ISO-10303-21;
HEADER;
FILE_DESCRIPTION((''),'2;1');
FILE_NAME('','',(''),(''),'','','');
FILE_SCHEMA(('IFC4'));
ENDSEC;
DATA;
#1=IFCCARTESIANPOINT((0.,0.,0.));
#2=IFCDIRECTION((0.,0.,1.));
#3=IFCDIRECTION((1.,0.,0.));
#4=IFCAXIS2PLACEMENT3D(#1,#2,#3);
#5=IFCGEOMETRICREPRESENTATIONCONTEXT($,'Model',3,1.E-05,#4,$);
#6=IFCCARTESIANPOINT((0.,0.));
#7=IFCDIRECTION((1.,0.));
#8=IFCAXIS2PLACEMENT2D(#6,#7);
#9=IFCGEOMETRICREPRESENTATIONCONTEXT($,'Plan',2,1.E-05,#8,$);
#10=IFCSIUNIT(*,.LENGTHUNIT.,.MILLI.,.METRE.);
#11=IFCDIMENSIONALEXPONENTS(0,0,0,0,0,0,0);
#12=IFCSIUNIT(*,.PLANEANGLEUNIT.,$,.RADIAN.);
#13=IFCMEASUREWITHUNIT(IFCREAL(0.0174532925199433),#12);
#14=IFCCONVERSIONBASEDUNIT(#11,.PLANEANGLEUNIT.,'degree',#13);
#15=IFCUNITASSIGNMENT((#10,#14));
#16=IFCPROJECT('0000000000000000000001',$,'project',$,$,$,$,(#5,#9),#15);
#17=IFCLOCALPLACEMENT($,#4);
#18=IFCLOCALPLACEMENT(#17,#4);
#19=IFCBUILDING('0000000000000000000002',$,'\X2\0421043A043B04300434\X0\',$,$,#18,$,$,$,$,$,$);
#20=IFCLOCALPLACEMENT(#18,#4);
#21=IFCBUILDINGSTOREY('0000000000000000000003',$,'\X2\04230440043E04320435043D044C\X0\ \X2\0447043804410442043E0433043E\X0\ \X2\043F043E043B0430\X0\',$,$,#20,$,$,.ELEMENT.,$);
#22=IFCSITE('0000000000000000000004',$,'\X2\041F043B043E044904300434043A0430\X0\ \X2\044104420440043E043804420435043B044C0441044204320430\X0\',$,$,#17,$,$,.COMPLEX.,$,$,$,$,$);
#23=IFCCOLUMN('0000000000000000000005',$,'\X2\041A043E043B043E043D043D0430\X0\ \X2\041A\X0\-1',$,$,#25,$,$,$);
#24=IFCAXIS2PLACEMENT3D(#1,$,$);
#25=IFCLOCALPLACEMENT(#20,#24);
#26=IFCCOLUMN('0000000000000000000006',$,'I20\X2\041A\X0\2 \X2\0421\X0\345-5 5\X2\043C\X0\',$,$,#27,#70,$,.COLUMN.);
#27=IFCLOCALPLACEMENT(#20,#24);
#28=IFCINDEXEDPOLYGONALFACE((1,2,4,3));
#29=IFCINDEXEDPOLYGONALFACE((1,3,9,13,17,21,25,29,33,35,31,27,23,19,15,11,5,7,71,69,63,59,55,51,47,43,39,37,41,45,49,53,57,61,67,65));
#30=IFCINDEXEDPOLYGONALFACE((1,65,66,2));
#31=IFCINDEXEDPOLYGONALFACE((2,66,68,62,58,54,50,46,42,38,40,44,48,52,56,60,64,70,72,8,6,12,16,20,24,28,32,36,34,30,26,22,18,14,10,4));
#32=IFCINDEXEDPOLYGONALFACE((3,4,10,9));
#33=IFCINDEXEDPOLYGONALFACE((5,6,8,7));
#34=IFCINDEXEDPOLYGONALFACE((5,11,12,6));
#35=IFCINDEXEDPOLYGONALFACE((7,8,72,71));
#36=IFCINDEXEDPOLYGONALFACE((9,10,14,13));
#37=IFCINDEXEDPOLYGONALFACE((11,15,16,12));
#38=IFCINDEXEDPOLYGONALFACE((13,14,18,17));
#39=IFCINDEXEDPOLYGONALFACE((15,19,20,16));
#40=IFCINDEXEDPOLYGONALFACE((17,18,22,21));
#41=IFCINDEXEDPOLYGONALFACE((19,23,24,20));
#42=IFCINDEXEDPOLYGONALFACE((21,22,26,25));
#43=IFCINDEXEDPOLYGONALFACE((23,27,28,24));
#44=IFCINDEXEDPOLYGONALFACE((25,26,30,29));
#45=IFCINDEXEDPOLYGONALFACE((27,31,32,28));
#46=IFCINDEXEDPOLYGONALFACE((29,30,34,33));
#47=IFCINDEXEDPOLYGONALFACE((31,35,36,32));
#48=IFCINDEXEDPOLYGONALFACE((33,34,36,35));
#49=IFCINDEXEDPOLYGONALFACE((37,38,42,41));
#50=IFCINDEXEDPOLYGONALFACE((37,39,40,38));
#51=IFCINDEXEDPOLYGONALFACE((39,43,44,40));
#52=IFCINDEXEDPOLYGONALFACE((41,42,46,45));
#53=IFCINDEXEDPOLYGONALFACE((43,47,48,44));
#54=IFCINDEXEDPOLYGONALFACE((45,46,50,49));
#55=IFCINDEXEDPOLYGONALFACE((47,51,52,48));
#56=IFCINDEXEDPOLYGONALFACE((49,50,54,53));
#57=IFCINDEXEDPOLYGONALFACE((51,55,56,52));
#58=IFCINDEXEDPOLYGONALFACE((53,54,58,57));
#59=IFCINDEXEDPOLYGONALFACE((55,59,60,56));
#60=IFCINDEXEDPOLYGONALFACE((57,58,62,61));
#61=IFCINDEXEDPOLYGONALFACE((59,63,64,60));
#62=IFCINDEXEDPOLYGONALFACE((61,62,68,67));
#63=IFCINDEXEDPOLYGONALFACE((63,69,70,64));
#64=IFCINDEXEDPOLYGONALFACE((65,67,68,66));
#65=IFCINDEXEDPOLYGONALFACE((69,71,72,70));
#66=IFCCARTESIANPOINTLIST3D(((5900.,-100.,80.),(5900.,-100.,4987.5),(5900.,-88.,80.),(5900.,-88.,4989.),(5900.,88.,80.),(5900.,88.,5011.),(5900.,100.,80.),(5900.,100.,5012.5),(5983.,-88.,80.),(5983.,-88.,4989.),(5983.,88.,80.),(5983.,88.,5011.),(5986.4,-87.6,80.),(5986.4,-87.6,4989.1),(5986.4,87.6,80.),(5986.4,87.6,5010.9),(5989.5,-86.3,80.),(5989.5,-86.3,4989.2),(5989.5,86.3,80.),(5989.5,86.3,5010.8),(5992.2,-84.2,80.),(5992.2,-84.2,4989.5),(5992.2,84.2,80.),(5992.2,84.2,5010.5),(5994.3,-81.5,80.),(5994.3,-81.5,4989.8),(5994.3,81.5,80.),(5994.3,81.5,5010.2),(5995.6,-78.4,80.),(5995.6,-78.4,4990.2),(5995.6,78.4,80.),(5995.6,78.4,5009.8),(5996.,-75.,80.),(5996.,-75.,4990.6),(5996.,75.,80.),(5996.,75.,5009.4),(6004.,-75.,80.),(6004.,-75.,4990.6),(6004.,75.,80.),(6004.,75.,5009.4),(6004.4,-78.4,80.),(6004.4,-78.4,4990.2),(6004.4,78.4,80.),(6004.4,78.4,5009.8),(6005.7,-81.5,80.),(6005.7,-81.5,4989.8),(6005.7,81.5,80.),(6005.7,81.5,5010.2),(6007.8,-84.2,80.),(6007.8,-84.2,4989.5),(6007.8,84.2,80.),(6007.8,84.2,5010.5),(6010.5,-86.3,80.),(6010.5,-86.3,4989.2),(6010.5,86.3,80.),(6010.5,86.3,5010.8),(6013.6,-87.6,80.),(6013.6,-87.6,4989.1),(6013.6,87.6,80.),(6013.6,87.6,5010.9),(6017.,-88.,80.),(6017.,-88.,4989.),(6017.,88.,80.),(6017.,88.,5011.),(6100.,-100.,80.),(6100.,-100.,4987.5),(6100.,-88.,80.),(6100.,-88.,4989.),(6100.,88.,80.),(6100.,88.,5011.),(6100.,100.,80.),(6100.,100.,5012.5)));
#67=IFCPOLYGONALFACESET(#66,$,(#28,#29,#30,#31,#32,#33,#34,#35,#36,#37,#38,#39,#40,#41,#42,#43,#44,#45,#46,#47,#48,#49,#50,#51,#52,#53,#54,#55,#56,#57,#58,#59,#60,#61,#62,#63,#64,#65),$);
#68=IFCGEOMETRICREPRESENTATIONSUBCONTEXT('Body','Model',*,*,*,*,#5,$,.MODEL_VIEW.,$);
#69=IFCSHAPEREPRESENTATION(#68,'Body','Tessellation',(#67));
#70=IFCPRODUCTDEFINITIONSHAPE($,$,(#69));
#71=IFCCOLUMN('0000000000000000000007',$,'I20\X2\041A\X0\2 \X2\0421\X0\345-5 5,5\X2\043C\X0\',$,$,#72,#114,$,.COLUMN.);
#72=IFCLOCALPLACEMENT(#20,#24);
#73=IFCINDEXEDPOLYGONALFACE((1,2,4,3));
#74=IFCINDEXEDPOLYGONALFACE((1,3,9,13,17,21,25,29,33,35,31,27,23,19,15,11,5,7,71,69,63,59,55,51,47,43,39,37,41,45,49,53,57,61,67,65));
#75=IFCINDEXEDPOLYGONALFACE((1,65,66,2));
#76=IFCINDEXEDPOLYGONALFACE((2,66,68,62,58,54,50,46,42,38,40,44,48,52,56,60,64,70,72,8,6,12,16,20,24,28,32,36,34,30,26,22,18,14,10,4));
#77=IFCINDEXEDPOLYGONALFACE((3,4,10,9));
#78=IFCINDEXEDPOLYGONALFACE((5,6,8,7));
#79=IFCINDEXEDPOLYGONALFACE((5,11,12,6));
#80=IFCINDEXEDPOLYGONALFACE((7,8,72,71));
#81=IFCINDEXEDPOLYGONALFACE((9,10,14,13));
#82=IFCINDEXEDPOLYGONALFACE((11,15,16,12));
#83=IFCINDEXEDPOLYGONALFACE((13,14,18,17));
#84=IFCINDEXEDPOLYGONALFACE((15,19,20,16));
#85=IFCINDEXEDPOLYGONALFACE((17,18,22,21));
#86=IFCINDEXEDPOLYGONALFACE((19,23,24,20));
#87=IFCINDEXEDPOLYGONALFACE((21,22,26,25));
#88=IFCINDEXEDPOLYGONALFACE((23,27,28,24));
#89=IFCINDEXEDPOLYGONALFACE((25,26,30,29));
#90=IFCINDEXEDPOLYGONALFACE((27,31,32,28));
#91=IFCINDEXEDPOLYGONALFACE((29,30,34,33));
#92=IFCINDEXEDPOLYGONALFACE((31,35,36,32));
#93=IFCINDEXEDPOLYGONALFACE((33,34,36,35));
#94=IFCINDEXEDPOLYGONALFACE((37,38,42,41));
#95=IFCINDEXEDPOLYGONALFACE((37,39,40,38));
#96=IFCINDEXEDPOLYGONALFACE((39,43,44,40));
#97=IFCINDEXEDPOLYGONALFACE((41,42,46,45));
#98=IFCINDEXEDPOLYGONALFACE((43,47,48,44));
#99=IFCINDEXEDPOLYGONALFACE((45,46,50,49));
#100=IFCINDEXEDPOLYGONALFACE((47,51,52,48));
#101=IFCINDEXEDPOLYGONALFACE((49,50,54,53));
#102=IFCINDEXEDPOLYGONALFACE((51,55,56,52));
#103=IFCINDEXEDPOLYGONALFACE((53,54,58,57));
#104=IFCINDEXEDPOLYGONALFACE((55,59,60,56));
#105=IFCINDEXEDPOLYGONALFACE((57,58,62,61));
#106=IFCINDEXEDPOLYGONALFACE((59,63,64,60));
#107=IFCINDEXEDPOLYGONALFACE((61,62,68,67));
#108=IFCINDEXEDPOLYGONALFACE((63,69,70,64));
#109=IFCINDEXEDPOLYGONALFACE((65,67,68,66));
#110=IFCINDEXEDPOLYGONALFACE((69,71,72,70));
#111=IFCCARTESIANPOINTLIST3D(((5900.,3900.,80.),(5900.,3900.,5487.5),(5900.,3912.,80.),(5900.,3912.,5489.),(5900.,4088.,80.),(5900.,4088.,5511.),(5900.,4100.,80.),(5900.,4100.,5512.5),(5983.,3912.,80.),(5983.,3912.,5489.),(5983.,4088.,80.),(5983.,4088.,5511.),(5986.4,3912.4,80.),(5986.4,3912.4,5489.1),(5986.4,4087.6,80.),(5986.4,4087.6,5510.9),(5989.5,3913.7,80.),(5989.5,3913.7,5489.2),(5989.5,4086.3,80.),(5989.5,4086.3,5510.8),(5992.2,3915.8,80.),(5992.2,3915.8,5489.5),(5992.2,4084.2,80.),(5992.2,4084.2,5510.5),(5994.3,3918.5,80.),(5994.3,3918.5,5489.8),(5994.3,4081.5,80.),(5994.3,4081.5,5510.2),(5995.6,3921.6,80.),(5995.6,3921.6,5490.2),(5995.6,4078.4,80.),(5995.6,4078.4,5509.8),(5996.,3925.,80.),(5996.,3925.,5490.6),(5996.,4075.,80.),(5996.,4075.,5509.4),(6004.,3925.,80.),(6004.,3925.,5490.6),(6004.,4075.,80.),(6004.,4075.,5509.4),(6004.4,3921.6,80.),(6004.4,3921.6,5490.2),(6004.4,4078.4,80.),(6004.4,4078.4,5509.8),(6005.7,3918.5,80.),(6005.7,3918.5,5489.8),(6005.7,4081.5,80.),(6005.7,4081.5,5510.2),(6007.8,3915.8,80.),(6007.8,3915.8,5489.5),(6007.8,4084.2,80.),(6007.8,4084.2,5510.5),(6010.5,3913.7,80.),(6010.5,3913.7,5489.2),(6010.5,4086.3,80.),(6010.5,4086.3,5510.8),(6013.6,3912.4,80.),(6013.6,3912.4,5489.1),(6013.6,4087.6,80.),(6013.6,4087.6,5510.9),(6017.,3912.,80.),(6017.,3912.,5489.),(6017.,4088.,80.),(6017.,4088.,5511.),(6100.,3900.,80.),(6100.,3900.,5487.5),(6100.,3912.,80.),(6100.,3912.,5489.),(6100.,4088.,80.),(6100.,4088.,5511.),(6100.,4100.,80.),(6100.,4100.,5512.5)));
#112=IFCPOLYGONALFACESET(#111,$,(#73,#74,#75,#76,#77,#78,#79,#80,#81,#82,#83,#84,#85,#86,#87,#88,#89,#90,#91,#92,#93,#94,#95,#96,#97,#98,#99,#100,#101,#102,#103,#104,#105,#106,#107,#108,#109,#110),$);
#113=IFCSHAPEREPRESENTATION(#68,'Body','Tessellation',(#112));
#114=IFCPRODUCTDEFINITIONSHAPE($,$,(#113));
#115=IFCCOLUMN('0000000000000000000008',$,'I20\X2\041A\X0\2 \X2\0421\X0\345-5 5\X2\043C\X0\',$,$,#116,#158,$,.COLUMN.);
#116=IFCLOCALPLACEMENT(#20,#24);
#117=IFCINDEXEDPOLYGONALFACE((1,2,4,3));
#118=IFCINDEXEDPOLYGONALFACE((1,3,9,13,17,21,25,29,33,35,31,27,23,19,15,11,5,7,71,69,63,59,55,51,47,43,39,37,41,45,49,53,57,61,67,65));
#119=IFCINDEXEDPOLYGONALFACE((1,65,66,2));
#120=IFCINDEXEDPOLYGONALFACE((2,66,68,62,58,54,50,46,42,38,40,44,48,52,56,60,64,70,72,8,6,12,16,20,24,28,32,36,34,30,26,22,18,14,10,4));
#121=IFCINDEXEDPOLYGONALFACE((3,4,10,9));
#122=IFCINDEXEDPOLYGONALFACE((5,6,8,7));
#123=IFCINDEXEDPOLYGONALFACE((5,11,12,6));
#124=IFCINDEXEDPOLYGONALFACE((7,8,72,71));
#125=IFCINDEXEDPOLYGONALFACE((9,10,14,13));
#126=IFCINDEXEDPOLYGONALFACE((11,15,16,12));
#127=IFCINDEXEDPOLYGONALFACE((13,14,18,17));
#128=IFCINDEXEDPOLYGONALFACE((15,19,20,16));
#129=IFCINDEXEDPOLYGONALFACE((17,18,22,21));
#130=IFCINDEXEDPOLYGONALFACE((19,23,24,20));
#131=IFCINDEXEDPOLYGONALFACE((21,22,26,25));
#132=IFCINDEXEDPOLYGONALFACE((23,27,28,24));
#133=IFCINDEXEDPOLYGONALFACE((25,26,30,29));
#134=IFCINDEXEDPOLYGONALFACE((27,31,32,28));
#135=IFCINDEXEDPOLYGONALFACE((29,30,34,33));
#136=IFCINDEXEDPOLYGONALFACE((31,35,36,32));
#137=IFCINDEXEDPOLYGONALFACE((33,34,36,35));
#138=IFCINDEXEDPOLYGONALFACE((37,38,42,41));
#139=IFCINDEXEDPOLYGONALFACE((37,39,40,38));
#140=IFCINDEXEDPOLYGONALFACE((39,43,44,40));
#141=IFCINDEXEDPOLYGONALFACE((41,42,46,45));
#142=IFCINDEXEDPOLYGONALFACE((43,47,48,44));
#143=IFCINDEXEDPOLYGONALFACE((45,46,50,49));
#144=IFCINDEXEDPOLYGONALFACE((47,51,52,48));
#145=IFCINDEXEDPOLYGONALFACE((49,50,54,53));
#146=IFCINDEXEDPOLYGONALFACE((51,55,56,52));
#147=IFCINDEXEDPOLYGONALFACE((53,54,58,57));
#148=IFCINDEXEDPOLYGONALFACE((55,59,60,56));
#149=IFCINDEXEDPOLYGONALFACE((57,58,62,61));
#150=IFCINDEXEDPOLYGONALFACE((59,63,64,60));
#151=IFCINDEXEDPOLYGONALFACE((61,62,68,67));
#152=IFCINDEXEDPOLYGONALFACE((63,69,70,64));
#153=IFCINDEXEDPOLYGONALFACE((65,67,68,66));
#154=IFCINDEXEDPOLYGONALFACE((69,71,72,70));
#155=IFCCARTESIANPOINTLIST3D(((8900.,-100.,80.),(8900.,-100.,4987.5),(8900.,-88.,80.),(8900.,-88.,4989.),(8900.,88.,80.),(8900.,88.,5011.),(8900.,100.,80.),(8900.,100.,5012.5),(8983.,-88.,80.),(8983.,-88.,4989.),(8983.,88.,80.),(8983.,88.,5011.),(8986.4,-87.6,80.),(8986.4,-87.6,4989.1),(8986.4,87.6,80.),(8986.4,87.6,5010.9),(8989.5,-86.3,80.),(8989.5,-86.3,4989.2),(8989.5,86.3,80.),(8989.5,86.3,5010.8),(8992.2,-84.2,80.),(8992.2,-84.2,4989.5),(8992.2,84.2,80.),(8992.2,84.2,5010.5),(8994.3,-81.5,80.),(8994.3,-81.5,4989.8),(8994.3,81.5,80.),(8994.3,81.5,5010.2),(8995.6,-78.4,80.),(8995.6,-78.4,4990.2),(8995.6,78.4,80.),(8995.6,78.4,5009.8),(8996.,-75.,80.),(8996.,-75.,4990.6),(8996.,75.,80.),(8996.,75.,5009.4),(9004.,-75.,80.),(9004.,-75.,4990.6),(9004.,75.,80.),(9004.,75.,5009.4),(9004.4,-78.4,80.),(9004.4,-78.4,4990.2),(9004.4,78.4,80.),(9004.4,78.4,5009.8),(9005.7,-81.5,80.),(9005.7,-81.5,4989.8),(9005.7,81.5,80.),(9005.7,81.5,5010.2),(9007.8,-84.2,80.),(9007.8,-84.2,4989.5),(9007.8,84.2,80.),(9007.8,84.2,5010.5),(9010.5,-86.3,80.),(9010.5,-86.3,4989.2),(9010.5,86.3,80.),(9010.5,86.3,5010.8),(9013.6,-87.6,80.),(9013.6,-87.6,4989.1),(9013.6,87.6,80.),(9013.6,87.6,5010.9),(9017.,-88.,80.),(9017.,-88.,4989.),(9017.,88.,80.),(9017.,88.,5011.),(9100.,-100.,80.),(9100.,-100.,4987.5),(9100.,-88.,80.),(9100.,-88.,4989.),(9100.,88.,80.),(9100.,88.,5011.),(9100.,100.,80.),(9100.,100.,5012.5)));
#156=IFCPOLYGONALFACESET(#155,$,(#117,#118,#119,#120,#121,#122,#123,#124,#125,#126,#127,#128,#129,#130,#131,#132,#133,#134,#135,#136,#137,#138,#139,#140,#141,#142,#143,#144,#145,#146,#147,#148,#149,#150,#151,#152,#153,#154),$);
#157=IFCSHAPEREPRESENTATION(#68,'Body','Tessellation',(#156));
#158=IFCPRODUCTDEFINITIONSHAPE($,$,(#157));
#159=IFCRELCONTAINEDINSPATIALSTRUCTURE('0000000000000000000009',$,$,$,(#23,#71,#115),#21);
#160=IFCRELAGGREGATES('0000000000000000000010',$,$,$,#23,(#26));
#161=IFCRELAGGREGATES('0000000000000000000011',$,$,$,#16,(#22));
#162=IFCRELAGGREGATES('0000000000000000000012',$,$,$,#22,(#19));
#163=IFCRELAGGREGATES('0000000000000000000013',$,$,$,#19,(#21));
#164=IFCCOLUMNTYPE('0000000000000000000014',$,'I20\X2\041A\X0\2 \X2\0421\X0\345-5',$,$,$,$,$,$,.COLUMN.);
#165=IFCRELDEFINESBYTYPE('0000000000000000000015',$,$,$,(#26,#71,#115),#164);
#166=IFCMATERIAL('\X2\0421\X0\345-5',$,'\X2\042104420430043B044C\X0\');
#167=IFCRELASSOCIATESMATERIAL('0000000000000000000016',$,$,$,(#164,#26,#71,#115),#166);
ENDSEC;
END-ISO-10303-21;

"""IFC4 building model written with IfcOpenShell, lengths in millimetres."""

from ifc_helpers import new_model, entity, si_unit, converted_unit, frame, origin_with_axes, origin_2d_with_axis, place, context, subcontext, project, spatial, i_section, extrude, boolean, clip, halfspace, material, material_profile, profile_set, profile_usage, type_object, element, aggregate, save


model = new_model("IFC4")

# Units and contexts
model_context = context("Model", 3, precision=1e-05, world=origin_with_axes())
plan_context = context("Plan", 2, precision=1e-05, world=origin_2d_with_axis())
body_context = subcontext(model_context, "Body", "Model", "MODEL_VIEW")
ifc_project = project(units=[si_unit("LENGTHUNIT", "METRE", prefix="MILLI"), converted_unit("PLANEANGLEUNIT", "degree", entity("IfcReal", 0.0174532925199433), si_unit("PLANEANGLEUNIT", "RADIAN"), dimensions=[0, 0, 0, 0, 0, 0, 0])], contexts=[model_context, plan_context])

# Site, building, storey
site_placement = place(None, origin_with_axes())
site = spatial("IfcSite", under=ifc_project, at=site_placement, Name="Площадка строительства", CompositionType="COMPLEX")
building_placement = place(site_placement, origin_with_axes())
building = spatial("IfcBuilding", under=site, at=building_placement, Name="Склад")
storey_placement = place(building_placement, origin_with_axes())
storey = spatial("IfcBuildingStorey", under=building, at=storey_placement, Name="Уровень чистого пола", CompositionType="ELEMENT")

# Columns
column_1_placement = place(storey_placement, origin_with_axes())
column_1 = element("IfcColumn", 1, at=column_1_placement, inside=storey, Name="Колонна К-1")
ifc_material_1 = material(Name="С345-5", Category="Сталь")
ifc_material_profile_1 = material_profile(ifc_material_1, i_section(OverallWidth=200.0, OverallDepth=200.0, WebThickness=8.0, FlangeThickness=12.0, FilletRadius=13.0, FlangeEdgeRadius=0.0, FlangeSlope=0.0))
ifc_profile_set_1 = profile_set([ifc_material_profile_1], Name="I20К2_С345-5")
ifc_profile_usage_1 = profile_usage(ifc_profile_set_1, cardinal=5)
column_type = type_object("IfcColumnType", Name="I20К2 С345-5", PredefinedType="COLUMN", material=ifc_profile_set_1)
column_2_placement = place(column_1_placement, frame((6000.0, 0.0, 0.0), z_axis=(0.0, 0.0, 1.0), x_axis=(1.0, 0.0, 0.0)))
column_2 = element("IfcColumn", 2, at=column_2_placement, type_object=column_type, material=ifc_profile_usage_1, Name="I20К2 С345-5 5м", PredefinedType="COLUMN", context=body_context, shape_type="Clipping", body=[
    boolean("DIFFERENCE", clip(extrude(i_section(OverallWidth=200.0, OverallDepth=200.0, WebThickness=8.0, FlangeThickness=12.0, FilletRadius=13.0, FlangeEdgeRadius=0.0, FlangeSlope=0.0), origin_with_axes(), (0.0, 0.0, 1.0), 5200.0), halfspace(frame((0.0, -298.5, 4962.7), z_axis=(0.0, -0.124035, 0.992278), x_axis=(0.0, 0.992278, 0.124035)), False)), halfspace(frame((0.0, 0.0, 80.0), z_axis=(0.0, 0.0, -1.0), x_axis=(1.0, 0.0, 0.0)), False)),
])
ifc_profile_usage_2 = profile_usage(ifc_profile_set_1, cardinal=5)
column_3_placement = place(storey_placement, frame((6000.0, 4000.0, 0.0), z_axis=(0.0, 0.0, 1.0), x_axis=(1.0, 0.0, 0.0)))
element("IfcColumn", 3, at=column_3_placement, inside=storey, type_object=column_type, material=ifc_profile_usage_2, Name="I20К2 С345-5 5,5м", PredefinedType="COLUMN", context=body_context, shape_type="Clipping", body=[
    boolean("DIFFERENCE", clip(extrude(i_section(OverallWidth=200.0, OverallDepth=200.0, WebThickness=8.0, FlangeThickness=12.0, FilletRadius=13.0, FlangeEdgeRadius=0.0, FlangeSlope=0.0), origin_with_axes(), (0.0, 0.0, 1.0), 5700.0), halfspace(frame((0.0, -4298.5, 4962.7), z_axis=(0.0, -0.124035, 0.992278), x_axis=(0.0, 0.992278, 0.124035)), False)), halfspace(frame((0.0, 0.0, 80.0), z_axis=(0.0, 0.0, -1.0), x_axis=(1.0, 0.0, 0.0)), False)),
])
ifc_profile_usage_3 = profile_usage(ifc_profile_set_1, cardinal=5)
column_4_placement = place(storey_placement, frame((9000.0, 0.0, 0.0), z_axis=(0.0, 0.0, 1.0), x_axis=(1.0, 0.0, 0.0)))
element("IfcColumn", 4, at=column_4_placement, inside=storey, type_object=column_type, material=ifc_profile_usage_3, Name="I20К2 С345-5 5м", PredefinedType="COLUMN", context=body_context, shape_type="Clipping", body=[
    boolean("DIFFERENCE", clip(extrude(i_section(OverallWidth=200.0, OverallDepth=200.0, WebThickness=8.0, FlangeThickness=12.0, FilletRadius=13.0, FlangeEdgeRadius=0.0, FlangeSlope=0.0), origin_with_axes(), (0.0, 0.0, 1.0), 5200.0), halfspace(frame((0.0, -298.5, 4962.7), z_axis=(0.0, -0.124035, 0.992278), x_axis=(0.0, 0.992278, 0.124035)), False)), halfspace(frame((0.0, 0.0, 80.0), z_axis=(0.0, 0.0, -1.0), x_axis=(1.0, 0.0, 0.0)), False)),
])

aggregate(column_1, [column_2])

save(model, "model.ifc")
